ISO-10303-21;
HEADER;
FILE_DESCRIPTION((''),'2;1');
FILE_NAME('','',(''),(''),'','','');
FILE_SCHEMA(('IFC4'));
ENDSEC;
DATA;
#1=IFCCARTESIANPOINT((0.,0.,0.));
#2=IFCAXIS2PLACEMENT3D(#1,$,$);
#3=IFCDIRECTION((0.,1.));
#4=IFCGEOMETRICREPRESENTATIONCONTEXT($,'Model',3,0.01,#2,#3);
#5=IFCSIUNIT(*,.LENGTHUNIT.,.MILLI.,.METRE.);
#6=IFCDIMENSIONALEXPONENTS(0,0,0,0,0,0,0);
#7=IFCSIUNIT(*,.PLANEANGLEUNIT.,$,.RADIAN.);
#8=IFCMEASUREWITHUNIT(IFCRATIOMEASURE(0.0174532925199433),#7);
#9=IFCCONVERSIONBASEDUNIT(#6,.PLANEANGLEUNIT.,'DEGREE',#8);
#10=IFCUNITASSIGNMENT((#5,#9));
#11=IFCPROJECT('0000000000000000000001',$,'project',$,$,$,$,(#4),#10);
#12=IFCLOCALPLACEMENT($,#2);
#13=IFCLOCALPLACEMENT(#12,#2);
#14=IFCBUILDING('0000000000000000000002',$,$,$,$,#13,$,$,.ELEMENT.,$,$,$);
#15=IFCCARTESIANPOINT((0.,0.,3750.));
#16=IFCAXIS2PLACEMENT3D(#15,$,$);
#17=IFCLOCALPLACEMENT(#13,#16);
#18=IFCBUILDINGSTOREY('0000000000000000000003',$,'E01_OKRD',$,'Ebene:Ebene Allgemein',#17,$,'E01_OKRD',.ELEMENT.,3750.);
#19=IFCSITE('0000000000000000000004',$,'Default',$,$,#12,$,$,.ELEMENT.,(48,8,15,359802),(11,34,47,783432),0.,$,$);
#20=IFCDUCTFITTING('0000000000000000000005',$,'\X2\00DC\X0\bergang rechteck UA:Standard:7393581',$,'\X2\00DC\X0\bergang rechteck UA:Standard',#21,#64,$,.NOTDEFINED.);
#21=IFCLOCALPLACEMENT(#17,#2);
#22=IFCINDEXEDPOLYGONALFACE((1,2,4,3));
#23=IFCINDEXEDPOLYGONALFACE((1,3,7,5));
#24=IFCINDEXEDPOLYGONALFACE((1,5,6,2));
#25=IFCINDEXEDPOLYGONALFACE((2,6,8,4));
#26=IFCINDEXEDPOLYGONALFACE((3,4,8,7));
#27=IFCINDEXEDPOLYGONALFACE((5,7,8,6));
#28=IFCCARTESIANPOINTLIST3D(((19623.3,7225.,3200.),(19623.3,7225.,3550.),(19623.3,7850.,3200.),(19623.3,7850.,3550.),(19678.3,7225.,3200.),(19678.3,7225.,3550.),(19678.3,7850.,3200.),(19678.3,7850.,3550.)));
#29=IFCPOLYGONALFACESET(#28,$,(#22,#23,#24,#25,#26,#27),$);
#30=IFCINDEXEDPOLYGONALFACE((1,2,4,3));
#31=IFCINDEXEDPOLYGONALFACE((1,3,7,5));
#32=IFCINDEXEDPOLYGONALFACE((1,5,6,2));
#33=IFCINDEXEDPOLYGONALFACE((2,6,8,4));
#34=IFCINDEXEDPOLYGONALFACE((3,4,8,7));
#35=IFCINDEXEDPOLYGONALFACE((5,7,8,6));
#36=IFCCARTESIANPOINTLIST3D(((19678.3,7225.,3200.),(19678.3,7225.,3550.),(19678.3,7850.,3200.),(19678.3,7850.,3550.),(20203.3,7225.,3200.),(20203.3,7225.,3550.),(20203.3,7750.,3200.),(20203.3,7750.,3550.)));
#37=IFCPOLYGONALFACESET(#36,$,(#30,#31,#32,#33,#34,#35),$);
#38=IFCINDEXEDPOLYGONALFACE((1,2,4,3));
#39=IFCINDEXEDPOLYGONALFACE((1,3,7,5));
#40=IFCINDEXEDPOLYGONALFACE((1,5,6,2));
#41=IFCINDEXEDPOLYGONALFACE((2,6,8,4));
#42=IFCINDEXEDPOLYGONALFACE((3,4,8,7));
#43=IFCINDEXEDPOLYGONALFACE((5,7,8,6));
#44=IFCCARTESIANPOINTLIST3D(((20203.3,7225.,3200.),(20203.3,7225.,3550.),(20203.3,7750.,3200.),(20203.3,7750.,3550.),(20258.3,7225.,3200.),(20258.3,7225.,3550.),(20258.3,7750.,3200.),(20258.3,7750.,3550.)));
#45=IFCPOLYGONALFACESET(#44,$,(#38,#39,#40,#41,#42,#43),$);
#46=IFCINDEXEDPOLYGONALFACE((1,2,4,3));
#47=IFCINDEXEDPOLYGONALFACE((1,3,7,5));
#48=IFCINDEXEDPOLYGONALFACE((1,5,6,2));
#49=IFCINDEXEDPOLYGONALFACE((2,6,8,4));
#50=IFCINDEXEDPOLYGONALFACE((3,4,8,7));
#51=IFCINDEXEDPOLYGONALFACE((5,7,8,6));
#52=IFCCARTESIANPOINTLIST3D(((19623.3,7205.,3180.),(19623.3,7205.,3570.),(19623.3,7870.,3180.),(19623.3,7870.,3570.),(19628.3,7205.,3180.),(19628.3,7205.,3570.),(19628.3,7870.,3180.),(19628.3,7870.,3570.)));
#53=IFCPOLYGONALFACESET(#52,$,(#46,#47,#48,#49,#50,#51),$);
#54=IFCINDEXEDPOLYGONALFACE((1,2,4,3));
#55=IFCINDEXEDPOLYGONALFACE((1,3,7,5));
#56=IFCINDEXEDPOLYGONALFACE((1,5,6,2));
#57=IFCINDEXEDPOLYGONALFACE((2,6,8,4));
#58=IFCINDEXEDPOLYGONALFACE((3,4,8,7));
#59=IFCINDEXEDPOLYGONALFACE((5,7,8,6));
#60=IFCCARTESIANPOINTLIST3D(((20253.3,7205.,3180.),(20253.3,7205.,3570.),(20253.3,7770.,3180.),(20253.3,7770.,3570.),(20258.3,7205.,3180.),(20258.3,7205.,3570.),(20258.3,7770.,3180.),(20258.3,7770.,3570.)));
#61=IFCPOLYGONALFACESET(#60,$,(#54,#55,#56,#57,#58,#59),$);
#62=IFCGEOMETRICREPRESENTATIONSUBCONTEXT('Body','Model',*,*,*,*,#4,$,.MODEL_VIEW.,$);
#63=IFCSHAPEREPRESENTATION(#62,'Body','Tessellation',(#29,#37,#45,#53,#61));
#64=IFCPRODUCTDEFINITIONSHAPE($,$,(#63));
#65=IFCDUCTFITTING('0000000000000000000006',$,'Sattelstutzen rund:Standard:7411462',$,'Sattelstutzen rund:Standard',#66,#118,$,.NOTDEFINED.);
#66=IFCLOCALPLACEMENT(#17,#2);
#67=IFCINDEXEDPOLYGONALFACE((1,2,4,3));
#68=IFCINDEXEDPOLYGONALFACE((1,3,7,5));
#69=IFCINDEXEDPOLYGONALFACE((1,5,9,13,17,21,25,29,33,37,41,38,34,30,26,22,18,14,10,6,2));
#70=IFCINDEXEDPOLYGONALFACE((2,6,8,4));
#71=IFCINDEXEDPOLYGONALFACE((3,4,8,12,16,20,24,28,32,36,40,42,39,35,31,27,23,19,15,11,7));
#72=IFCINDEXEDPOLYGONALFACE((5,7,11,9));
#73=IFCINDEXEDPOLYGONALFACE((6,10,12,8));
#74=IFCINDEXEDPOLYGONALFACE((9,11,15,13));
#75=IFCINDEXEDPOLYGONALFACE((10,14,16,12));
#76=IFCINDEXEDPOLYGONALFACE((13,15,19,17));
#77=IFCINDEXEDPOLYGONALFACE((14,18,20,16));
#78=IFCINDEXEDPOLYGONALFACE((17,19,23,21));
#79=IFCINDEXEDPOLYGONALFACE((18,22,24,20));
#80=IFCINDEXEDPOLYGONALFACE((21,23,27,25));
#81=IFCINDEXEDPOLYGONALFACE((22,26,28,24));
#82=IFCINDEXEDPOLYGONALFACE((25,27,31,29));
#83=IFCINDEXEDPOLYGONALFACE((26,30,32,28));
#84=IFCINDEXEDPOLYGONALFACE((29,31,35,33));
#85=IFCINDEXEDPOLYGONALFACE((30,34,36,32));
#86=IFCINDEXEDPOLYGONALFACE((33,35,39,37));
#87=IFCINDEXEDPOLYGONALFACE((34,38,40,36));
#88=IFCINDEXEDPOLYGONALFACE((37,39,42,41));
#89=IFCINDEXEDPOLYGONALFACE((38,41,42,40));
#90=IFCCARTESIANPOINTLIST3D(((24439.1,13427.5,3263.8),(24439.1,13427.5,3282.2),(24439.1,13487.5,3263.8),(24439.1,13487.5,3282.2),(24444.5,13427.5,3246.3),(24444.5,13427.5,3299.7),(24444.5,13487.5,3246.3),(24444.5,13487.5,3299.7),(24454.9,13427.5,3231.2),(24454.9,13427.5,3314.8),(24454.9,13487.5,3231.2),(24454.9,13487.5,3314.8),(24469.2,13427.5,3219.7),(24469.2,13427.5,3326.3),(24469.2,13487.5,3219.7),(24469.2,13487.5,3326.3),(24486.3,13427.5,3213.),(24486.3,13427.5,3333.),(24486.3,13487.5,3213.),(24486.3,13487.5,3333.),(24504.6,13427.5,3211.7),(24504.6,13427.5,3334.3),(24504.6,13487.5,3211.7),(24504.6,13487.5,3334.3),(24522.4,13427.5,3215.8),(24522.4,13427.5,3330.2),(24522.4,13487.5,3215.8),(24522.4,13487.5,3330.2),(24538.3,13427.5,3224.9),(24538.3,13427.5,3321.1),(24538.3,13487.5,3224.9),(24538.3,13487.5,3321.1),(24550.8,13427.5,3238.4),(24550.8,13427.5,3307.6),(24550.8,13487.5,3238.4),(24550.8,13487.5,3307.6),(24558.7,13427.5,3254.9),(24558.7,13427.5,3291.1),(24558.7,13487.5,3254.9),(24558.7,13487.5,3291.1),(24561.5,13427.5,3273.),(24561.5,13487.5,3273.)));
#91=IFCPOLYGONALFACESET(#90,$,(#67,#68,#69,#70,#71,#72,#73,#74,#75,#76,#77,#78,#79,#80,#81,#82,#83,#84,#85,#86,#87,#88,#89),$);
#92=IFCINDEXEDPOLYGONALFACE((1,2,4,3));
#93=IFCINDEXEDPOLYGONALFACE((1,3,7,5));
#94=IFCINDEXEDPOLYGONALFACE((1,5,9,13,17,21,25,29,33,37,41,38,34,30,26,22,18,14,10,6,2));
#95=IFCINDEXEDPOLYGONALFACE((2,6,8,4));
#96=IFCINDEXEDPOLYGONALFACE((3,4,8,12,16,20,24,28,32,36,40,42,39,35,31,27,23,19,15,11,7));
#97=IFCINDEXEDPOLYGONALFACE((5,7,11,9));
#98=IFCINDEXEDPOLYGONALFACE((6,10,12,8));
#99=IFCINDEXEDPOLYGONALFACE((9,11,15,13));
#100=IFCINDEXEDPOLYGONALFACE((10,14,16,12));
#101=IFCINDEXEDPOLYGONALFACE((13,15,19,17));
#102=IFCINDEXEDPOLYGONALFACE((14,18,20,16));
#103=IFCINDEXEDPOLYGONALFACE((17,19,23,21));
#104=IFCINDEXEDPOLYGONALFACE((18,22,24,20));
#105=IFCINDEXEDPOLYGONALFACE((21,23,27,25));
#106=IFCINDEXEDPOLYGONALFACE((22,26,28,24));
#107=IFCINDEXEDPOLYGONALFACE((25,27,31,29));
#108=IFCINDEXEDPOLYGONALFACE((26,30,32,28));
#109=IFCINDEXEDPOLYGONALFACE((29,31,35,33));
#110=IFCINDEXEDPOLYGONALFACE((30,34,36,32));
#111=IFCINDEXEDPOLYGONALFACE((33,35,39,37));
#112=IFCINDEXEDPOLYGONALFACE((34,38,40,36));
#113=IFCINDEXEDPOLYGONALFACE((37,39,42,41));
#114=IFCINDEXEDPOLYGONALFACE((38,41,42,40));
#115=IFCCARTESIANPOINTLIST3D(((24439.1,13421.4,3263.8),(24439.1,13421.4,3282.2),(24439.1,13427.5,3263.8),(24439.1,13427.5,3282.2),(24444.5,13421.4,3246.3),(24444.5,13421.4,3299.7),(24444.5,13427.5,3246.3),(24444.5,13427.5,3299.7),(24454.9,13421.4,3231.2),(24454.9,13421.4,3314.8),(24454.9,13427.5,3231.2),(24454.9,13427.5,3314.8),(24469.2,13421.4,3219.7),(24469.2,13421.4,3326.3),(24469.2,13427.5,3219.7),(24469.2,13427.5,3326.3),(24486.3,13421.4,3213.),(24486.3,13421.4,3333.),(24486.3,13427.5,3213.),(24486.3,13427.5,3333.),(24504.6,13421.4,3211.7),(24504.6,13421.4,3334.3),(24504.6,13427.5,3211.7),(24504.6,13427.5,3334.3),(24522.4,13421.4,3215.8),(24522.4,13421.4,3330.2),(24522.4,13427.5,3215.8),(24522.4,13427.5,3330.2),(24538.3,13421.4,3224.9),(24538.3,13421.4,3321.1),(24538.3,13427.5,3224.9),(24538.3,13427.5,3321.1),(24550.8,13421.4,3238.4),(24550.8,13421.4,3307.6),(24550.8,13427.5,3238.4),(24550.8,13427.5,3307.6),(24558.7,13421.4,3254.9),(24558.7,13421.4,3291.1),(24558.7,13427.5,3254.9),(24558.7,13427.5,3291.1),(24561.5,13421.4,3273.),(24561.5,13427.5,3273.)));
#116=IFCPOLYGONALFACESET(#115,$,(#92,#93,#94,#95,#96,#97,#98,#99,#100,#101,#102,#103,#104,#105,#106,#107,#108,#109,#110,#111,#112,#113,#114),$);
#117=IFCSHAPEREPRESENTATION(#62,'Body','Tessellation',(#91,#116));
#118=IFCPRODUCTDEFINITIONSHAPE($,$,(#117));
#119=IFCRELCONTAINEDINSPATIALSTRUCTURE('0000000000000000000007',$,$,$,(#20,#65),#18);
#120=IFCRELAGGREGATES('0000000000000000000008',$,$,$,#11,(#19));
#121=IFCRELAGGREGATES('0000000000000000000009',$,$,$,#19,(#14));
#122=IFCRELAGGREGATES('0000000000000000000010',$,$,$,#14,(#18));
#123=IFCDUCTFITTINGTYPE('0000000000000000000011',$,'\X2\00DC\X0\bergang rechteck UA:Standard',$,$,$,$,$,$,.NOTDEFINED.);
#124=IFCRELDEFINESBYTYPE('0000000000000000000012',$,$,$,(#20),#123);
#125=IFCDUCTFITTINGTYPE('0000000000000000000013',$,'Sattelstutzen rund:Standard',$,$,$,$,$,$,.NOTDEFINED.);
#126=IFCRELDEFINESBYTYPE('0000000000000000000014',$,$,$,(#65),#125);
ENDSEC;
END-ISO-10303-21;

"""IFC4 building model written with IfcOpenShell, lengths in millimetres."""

from ifc_helpers import new_model, entity, si_unit, converted_unit, direction, frame, frame_2d, origin, origin_2d_with_axis, place, context, subcontext, project, spatial, polyline, rectangle, circle, outline, extrude, source, transform, mapped, type_object, type_shapes, element, save


model = new_model("IFC4")

# Units and contexts
model_context = context("Model", 3, precision=0.01, world=origin(), true_north=direction((0.0, 1.0)))
body_context = subcontext(model_context, "Body", "Model", "MODEL_VIEW")
ifc_project = project(units=[si_unit("LENGTHUNIT", "METRE", prefix="MILLI"), converted_unit("PLANEANGLEUNIT", "DEGREE", entity("IfcRatioMeasure", 0.0174532925199433), si_unit("PLANEANGLEUNIT", "RADIAN"), dimensions=[0, 0, 0, 0, 0, 0, 0])], contexts=[model_context])

# Site, building, storey
site_placement = place(None, origin())
site = spatial("IfcSite", under=ifc_project, at=site_placement, Name="Default", CompositionType="ELEMENT", RefLatitude=(48, 8, 15, 359802), RefLongitude=(11, 34, 47, 783432), RefElevation=0.0)
building_placement = place(site_placement, origin())
building = spatial("IfcBuilding", under=site, at=building_placement, CompositionType="ELEMENT")
storey_placement = place(building_placement, frame((0.0, 0.0, 3750.0)))
storey = spatial("IfcBuildingStorey", under=building, at=storey_placement, Name="E01_OKRD", ObjectType="Ebene:Ebene Allgemein", LongName="E01_OKRD", CompositionType="ELEMENT", Elevation=3750.0)

# Duct fittings
duct_fitting_type_1 = type_object("IfcDuctFittingType", Name="Übergang rechteck UA:Standard", PredefinedType="NOTDEFINED")
shared_shape_1 = source(origin(), body_context, "Body", "SweptSolid", [
    extrude(rectangle(XDim=55.0, YDim=625.0, at=origin_2d_with_axis()), frame((607.5, -50.0, -175.0)), (0.0, 0.0, 1.0), 350.0),
    extrude(outline(polyline([(-213.4, -282.4), (321.0, -282.4), (204.1, 331.5), (-311.7, 233.3), (-213.4, -282.4)])), frame((317.5, -25.0, -175.0), z_axis=(0.0, 0.0, 1.0), x_axis=(0.982339, -0.187112, 0.0)), (0.0, 0.0, 1.0), 350.0),
    extrude(rectangle(XDim=55.0, YDim=525.0, at=frame_2d((0.0, 0.0), x_axis=(1.0, 0.0))), frame((27.5, 0.0, -175.0)), (0.0, 0.0, 1.0), 350.0),
    extrude(rectangle(XDim=5.0, YDim=665.0, at=origin_2d_with_axis()), frame((632.5, -50.0, -195.0)), (0.0, 0.0, 1.0), 390.0),
    extrude(rectangle(XDim=5.0, YDim=565.0, at=frame_2d((0.0, 0.0), x_axis=(1.0, 0.0))), frame((2.5, 0.0, -195.0)), (0.0, 0.0, 1.0), 390.0),
])
type_shapes(duct_fitting_type_1, [shared_shape_1])
duct_fitting_1_placement = place(storey_placement, frame((20258.3, 7487.5, 3375.0), z_axis=(0.0, 0.0, 1.0), x_axis=(-1.0, 0.0, 0.0)))
element("IfcDuctFitting", 1, at=duct_fitting_1_placement, inside=storey, type_object=duct_fitting_type_1, Name="Übergang rechteck UA:Standard:7393581", ObjectType="Übergang rechteck UA:Standard", PredefinedType="NOTDEFINED", context=body_context, shape_type="MappedRepresentation", body=[
    mapped(shared_shape_1, transform((0.0, 0.0, 0.0), scale=1.0)),
])
duct_fitting_type_2 = type_object("IfcDuctFittingType", Name="Sattelstutzen rund:Standard", PredefinedType="NOTDEFINED")
shared_shape_2 = source(origin(), body_context, "Body", "SweptSolid", [
    extrude(circle(Radius=61.5, at=frame_2d((0.0, 0.0), x_axis=(1.0, 0.0))), frame((0.0, 0.0, 0.0), z_axis=(1.0, 0.0, 0.0), x_axis=(0.0, 1.0, 0.0)), (0.0, 0.0, 1.0), 60.0),
    extrude(circle(Radius=61.5, at=frame_2d((0.0, 0.0), x_axis=(1.0, 0.0))), frame((-6.1, 0.0, 0.0), z_axis=(1.0, 0.0, 0.0), x_axis=(0.0, 1.0, 0.0)), (0.0, 0.0, 1.0), 6.1),
])
type_shapes(duct_fitting_type_2, [shared_shape_2])
duct_fitting_2_placement = place(storey_placement, frame((24500.0, 13427.5, 3273.0), z_axis=(0.0, 0.0, -1.0), x_axis=(0.0, 1.0, 0.0)))
element("IfcDuctFitting", 2, at=duct_fitting_2_placement, inside=storey, type_object=duct_fitting_type_2, Name="Sattelstutzen rund:Standard:7411462", ObjectType="Sattelstutzen rund:Standard", PredefinedType="NOTDEFINED", context=body_context, shape_type="MappedRepresentation", body=[
    mapped(shared_shape_2, transform((0.0, 0.0, 0.0), scale=1.0)),
])

save(model, "model.ifc")
